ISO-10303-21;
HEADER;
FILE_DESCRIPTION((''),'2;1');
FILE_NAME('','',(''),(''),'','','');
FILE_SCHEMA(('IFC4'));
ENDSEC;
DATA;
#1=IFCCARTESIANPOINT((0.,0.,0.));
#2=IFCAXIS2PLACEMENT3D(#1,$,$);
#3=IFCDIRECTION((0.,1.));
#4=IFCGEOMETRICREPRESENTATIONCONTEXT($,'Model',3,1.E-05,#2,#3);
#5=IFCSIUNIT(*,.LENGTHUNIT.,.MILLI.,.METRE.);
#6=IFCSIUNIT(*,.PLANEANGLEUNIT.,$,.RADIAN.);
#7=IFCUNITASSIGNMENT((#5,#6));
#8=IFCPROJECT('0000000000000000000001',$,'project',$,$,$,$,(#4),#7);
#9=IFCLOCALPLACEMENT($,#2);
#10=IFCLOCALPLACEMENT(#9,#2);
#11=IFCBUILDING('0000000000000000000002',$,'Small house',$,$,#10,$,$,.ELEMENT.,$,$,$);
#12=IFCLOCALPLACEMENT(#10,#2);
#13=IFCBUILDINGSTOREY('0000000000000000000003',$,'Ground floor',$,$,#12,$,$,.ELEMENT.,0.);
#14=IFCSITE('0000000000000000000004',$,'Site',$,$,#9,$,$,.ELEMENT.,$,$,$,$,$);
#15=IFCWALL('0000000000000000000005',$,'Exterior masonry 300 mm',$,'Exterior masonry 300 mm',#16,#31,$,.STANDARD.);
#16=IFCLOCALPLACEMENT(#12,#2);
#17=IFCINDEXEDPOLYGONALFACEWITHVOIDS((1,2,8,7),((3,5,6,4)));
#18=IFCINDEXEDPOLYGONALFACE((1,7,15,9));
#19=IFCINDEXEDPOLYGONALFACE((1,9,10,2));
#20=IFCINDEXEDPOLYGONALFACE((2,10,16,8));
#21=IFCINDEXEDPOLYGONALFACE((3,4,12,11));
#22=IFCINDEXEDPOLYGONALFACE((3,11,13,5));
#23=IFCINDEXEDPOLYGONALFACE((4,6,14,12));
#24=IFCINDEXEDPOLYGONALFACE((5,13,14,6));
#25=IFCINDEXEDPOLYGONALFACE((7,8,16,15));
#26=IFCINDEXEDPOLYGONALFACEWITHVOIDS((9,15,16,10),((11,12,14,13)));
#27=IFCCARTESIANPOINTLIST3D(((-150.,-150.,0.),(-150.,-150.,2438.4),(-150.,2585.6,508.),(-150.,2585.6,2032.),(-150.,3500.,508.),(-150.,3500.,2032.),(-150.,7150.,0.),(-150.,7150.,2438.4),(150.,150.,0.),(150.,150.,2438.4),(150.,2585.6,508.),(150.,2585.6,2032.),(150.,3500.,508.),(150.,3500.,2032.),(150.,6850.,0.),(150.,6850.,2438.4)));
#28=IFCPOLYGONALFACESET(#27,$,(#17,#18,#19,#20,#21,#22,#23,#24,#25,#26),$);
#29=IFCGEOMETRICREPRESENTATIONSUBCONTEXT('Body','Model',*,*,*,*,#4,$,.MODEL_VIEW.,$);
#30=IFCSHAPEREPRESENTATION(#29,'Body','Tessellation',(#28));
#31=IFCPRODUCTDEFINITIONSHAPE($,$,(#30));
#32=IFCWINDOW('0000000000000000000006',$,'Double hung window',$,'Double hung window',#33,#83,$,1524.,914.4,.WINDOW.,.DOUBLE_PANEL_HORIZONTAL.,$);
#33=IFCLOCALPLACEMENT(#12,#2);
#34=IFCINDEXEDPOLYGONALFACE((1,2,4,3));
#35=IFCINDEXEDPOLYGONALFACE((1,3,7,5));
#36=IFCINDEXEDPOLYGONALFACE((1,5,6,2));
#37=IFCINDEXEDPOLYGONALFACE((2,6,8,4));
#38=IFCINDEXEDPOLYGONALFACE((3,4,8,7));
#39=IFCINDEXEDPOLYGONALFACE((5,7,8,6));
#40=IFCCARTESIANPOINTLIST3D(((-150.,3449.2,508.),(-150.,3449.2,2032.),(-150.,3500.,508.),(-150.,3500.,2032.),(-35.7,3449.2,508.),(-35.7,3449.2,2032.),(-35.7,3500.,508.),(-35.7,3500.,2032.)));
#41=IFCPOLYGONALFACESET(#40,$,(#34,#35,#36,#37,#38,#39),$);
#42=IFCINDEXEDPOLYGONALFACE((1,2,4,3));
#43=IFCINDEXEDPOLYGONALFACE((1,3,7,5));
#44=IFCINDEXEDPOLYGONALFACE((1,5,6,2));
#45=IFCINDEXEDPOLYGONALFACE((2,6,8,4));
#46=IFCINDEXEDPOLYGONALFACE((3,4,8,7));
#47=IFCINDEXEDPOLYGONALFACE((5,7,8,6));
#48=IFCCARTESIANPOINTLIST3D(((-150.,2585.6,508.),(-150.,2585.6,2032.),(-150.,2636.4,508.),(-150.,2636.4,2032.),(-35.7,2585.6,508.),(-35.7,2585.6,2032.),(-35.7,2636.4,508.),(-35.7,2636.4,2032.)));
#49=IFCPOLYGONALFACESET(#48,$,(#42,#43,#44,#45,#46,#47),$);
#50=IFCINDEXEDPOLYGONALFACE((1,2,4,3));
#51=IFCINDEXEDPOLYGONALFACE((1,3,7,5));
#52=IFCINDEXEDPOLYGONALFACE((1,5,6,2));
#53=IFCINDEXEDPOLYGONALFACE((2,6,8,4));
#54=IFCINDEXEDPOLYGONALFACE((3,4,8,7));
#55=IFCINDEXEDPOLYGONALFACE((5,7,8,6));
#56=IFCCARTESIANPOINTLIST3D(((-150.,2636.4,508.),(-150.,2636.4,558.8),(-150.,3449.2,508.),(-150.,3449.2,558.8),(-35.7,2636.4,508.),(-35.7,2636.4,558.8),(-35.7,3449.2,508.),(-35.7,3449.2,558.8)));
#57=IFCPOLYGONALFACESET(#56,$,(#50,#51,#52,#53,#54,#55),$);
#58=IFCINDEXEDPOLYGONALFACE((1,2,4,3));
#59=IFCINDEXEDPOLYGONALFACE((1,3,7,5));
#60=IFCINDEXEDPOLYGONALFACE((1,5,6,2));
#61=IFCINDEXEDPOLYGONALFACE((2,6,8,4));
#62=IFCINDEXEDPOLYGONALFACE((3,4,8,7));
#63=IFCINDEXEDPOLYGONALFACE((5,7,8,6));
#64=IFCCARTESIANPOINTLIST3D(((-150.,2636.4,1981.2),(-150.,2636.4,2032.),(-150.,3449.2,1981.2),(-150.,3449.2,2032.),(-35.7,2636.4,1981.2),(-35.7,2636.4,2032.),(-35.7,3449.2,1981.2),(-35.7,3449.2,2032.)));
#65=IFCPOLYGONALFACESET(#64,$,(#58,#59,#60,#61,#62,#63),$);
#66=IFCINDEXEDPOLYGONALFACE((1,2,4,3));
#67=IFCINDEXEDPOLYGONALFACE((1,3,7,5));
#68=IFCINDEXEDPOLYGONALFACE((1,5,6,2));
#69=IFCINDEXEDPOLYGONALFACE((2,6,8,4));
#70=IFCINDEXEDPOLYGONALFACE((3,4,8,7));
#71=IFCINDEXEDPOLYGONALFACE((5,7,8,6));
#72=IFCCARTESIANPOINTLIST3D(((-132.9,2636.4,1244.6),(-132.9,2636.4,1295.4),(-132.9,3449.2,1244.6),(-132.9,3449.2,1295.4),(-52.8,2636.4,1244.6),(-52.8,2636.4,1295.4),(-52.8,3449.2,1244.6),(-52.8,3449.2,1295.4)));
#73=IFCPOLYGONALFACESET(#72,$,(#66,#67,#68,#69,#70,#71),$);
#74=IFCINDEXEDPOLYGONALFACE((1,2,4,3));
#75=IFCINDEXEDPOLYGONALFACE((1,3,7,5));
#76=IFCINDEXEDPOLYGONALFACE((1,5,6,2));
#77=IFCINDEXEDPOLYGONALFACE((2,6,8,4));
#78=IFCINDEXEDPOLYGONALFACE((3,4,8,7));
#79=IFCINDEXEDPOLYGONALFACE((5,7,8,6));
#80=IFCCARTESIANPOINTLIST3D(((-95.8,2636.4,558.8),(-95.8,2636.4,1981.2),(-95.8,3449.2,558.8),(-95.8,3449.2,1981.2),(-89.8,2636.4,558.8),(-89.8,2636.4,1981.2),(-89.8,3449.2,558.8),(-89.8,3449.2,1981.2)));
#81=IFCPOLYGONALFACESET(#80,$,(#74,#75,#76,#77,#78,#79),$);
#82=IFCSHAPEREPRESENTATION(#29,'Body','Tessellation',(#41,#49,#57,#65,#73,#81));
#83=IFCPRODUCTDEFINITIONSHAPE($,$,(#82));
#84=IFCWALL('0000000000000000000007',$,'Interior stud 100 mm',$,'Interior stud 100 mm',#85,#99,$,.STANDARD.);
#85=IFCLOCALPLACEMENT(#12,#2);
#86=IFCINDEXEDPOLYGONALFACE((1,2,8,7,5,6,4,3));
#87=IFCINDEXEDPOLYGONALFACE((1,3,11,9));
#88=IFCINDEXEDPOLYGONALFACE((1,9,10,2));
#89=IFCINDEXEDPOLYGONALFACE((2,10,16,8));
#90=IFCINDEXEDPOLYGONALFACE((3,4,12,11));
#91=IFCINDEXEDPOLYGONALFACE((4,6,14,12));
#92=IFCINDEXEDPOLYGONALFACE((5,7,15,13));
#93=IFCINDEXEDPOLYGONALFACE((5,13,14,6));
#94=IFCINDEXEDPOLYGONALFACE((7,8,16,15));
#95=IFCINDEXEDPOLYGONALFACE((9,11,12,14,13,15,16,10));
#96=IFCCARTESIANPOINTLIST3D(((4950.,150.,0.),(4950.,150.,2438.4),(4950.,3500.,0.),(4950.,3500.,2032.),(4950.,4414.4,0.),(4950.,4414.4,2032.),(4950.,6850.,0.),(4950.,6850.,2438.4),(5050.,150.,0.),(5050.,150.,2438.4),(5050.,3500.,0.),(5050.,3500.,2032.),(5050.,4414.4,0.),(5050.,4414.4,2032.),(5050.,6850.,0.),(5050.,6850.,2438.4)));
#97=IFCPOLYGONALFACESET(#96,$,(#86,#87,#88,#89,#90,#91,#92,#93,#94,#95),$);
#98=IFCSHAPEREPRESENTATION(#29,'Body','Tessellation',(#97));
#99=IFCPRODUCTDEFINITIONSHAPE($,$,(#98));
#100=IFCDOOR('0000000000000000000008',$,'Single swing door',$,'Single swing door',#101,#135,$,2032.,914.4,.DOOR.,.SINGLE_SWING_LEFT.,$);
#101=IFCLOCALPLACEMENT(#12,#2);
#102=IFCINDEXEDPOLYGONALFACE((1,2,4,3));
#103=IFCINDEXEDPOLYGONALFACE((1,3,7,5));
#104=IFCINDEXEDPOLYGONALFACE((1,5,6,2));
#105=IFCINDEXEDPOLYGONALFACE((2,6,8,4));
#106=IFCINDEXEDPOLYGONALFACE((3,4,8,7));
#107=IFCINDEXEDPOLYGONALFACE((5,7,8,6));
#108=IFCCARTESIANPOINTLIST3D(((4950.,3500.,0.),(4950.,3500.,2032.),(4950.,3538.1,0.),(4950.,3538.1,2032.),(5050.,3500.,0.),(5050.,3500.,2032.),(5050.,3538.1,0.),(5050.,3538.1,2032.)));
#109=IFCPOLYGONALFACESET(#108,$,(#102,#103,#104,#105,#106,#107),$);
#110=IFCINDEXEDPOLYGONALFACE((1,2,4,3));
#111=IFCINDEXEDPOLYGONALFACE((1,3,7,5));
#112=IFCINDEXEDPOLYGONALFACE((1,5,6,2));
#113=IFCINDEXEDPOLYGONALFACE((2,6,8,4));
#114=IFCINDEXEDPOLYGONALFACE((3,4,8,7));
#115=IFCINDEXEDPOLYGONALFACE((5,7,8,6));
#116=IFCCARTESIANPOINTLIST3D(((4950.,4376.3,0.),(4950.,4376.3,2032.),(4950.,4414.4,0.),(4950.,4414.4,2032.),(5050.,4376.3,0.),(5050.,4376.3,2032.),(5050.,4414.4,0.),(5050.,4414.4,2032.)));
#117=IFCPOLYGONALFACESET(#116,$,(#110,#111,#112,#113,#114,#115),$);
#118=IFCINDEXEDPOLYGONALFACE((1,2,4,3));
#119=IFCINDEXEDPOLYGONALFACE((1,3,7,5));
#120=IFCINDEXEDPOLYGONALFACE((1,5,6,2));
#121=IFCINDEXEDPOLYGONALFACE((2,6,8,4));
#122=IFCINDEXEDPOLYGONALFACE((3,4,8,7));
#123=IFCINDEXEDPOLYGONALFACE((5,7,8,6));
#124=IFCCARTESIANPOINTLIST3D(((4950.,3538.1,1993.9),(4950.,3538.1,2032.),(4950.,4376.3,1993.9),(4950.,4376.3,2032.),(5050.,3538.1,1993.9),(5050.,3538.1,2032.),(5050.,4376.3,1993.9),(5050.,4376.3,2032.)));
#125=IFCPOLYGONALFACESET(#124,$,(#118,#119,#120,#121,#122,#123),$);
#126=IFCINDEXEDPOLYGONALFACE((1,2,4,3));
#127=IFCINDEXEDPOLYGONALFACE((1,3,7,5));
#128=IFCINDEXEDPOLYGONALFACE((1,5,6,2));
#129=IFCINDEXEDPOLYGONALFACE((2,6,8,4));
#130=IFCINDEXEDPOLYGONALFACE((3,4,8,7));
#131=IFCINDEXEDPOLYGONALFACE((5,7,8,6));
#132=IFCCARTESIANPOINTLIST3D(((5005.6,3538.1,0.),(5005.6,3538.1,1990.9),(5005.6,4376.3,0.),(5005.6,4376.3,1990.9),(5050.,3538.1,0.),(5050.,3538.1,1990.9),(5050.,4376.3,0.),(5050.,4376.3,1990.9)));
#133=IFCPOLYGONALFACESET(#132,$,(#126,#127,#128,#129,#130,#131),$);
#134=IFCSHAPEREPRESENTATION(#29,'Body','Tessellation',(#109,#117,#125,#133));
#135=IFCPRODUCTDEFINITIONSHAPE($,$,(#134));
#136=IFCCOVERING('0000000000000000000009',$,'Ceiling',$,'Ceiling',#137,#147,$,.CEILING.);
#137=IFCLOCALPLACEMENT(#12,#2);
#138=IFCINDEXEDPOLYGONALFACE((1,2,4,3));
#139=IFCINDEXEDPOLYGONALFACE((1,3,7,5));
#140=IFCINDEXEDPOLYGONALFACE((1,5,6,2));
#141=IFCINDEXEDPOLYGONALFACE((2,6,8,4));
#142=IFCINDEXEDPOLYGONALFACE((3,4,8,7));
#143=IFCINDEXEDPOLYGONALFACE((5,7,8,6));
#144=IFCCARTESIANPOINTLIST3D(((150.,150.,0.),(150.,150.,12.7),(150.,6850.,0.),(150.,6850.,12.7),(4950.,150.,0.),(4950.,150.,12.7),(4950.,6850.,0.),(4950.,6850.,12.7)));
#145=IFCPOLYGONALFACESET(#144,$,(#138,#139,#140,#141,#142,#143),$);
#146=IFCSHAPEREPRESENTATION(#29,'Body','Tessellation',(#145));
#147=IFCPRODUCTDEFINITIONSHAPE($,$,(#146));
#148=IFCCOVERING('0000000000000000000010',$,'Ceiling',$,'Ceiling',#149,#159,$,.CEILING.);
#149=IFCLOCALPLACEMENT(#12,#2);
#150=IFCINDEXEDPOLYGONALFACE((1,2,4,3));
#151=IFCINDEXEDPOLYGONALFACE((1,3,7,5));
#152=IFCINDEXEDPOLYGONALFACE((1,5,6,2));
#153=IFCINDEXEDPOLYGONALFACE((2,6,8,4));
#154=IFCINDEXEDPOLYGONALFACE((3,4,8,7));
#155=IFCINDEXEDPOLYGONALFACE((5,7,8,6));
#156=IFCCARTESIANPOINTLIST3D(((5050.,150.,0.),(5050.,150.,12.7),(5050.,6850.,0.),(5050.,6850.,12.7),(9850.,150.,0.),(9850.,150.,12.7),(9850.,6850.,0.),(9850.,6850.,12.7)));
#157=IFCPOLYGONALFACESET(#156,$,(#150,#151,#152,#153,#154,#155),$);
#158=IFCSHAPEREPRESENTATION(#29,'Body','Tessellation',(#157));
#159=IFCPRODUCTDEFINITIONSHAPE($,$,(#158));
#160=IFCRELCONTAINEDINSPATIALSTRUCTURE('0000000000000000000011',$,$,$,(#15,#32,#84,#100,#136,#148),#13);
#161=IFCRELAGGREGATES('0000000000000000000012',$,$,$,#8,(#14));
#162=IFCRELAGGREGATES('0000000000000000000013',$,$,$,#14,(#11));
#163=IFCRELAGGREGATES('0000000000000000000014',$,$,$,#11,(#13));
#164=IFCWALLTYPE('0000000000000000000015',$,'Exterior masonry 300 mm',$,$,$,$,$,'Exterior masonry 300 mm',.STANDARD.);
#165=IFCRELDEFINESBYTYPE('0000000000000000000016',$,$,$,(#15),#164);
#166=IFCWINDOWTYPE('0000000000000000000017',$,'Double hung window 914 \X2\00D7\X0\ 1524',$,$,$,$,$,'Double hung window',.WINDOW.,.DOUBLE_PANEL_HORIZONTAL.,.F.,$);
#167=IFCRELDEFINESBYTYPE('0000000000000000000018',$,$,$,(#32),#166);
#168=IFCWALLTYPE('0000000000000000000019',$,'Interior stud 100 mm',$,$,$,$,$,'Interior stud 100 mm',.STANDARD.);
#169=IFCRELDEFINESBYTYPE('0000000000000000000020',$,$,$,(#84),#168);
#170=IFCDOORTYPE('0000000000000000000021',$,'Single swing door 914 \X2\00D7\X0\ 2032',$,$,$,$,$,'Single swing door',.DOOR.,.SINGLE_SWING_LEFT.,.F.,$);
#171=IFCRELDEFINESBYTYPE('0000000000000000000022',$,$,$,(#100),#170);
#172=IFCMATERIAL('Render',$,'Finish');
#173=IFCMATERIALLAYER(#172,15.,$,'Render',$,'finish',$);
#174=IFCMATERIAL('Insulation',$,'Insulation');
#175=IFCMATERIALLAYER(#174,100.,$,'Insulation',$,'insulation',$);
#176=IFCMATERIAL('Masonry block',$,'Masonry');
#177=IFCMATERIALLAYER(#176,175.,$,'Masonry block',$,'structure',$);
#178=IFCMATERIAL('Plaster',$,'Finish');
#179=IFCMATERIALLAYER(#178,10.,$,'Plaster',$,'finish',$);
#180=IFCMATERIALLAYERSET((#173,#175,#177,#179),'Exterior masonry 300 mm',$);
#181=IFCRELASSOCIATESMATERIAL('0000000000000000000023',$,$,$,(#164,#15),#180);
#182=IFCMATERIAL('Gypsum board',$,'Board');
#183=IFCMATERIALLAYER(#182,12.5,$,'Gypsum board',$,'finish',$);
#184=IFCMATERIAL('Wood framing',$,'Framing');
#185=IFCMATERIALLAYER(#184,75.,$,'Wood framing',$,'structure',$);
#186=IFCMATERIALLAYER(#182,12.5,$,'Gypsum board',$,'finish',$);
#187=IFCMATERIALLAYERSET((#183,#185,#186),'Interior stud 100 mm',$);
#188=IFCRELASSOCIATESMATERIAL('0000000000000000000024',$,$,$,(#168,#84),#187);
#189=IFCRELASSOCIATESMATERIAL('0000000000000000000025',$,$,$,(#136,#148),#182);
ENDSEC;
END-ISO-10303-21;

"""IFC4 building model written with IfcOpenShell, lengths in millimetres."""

from ifc_helpers import new_model, si_unit, direction, frame, origin, origin_with_axes, place, context, subcontext, project, spatial, polyline, outline, extrude, material, layer, layer_set, layer_usage, type_object, element, fill, save


model = new_model("IFC4")

# Units and contexts
model_context = context("Model", 3, precision=1e-05, world=origin(), true_north=direction((0.0, 1.0)))
body_context = subcontext(model_context, "Body", "Model", "MODEL_VIEW")
ifc_project = project(units=[si_unit("LENGTHUNIT", "METRE", prefix="MILLI"), si_unit("PLANEANGLEUNIT", "RADIAN")], contexts=[model_context])

# Site, building, storey
site_placement = place(None, origin())
site = spatial("IfcSite", under=ifc_project, at=site_placement, Name="Site", CompositionType="ELEMENT")
building_placement = place(site_placement, origin())
building = spatial("IfcBuilding", under=site, at=building_placement, Name="Small house", CompositionType="ELEMENT")
storey_placement = place(building_placement, origin())
storey = spatial("IfcBuildingStorey", under=building, at=storey_placement, Name="Ground floor", CompositionType="ELEMENT", Elevation=0.0)

# Shared definitions
ifc_material_1 = material(Name="Render", Category="Finish")
ifc_layer_1 = layer(ifc_material_1, 15.0, Name="Render", Category="finish")
ifc_material_2 = material(Name="Insulation", Category="Insulation")
ifc_layer_2 = layer(ifc_material_2, 100.0, Name="Insulation", Category="insulation")
ifc_material_3 = material(Name="Masonry block", Category="Masonry")
ifc_layer_3 = layer(ifc_material_3, 175.0, Name="Masonry block", Category="structure")
ifc_material_4 = material(Name="Plaster", Category="Finish")
ifc_layer_4 = layer(ifc_material_4, 10.0, Name="Plaster", Category="finish")
ifc_layer_set_1 = layer_set([ifc_layer_1, ifc_layer_2, ifc_layer_3, ifc_layer_4], Name="Exterior masonry 300 mm")
wall_type_1 = type_object("IfcWallType", Name="Exterior masonry 300 mm", ElementType="Exterior masonry 300 mm", PredefinedType="STANDARD", material=ifc_layer_set_1)
door_type = type_object("IfcDoorType", Name="Single swing door 914 × 2032", ElementType="Single swing door", OperationType="SINGLE_SWING_LEFT", ParameterTakesPrecedence=False, PredefinedType="DOOR")
window_type = type_object("IfcWindowType", Name="Double hung window 914 × 1524", ElementType="Double hung window", ParameterTakesPrecedence=False, PartitioningType="DOUBLE_PANEL_HORIZONTAL", PredefinedType="WINDOW")

# Wall, opening, window
ifc_layer_usage_1 = layer_usage(ifc_layer_set_1, "AXIS2", "POSITIVE", -150.0)
wall_1_placement = place(storey_placement, frame((0.0, 7000.0, 0.0), z_axis=(0.0, 0.0, 1.0), x_axis=(0.0, -1.0, 0.0)))
wall_1 = element("IfcWall", 1, at=wall_1_placement, inside=storey, type_object=wall_type_1, material=ifc_layer_usage_1, Name="Exterior masonry 300 mm", ObjectType="Exterior masonry 300 mm", PredefinedType="STANDARD", context=body_context, shape_type="SweptSolid", body=[
    extrude(outline(polyline([(-150.0, -150.0), (7150.0, -150.0), (6850.0, 150.0), (150.0, 150.0), (-150.0, -150.0)])), origin(), (0.0, 0.0, 1.0), 2438.4),
])
opening_1_placement = place(wall_1_placement, frame((3500.0, 0.0, 508.0), z_axis=(0.0, 0.0, 1.0), x_axis=(1.0, 0.0, 0.0)))
opening_1 = element("IfcOpeningElement", 2, at=opening_1_placement, cuts=wall_1, PredefinedType="OPENING", context=body_context, shape_type="SweptSolid", body=[
    extrude(outline(polyline([(0.0, -160.0), (914.4, -160.0), (914.4, 160.0), (0.0, 160.0), (0.0, -160.0)])), origin(), (0.0, 0.0, 1.0), 1524.0),
])
window_1_placement = place(opening_1_placement, origin_with_axes())
window_1 = element("IfcWindow", 3, at=window_1_placement, inside=storey, type_object=window_type, Name="Double hung window", ObjectType="Double hung window", OverallHeight=1524.0, OverallWidth=914.4, PartitioningType="DOUBLE_PANEL_HORIZONTAL", PredefinedType="WINDOW", context=body_context, shape_type="SweptSolid", body=[
    extrude(outline(polyline([(0.0, -150.0), (50.8, -150.0), (50.8, -35.7), (0.0, -35.7), (0.0, -150.0)])), origin(), (0.0, 0.0, 1.0), 1524.0),
    extrude(outline(polyline([(863.6, -150.0), (914.4, -150.0), (914.4, -35.7), (863.6, -35.7), (863.6, -150.0)])), origin(), (0.0, 0.0, 1.0), 1524.0),
    extrude(outline(polyline([(50.8, -150.0), (863.6, -150.0), (863.6, -35.7), (50.8, -35.7), (50.8, -150.0)])), origin(), (0.0, 0.0, 1.0), 50.8),
    extrude(outline(polyline([(50.8, -150.0), (863.6, -150.0), (863.6, -35.7), (50.8, -35.7), (50.8, -150.0)])), frame((0.0, 0.0, 1473.2)), (0.0, 0.0, 1.0), 50.8),
    extrude(outline(polyline([(50.8, -132.9), (863.6, -132.9), (863.6, -52.8), (50.8, -52.8), (50.8, -132.9)])), frame((0.0, 0.0, 736.6)), (0.0, 0.0, 1.0), 50.8),
    extrude(outline(polyline([(50.8, -95.8), (863.6, -95.8), (863.6, -89.8), (50.8, -89.8), (50.8, -95.8)])), frame((0.0, 0.0, 50.8)), (0.0, 0.0, 1.0), 1422.4),
])
fill(opening_1, window_1)

# Wall, opening, door
ifc_material_5 = material(Name="Gypsum board", Category="Board")
ifc_layer_5 = layer(ifc_material_5, 12.5, Name="Gypsum board", Category="finish")
ifc_material_6 = material(Name="Wood framing", Category="Framing")
ifc_layer_6 = layer(ifc_material_6, 75.0, Name="Wood framing", Category="structure")
ifc_layer_7 = layer(ifc_material_5, 12.5, Name="Gypsum board", Category="finish")
ifc_layer_set_2 = layer_set([ifc_layer_5, ifc_layer_6, ifc_layer_7], Name="Interior stud 100 mm")
ifc_layer_usage_2 = layer_usage(ifc_layer_set_2, "AXIS2", "NEGATIVE", 50.0)
wall_type_2 = type_object("IfcWallType", Name="Interior stud 100 mm", ElementType="Interior stud 100 mm", PredefinedType="STANDARD", material=ifc_layer_set_2)
wall_2_placement = place(storey_placement, frame((5000.0, 0.0, 0.0), z_axis=(0.0, 0.0, 1.0), x_axis=(0.0, 1.0, 0.0)))
wall_2 = element("IfcWall", 4, at=wall_2_placement, inside=storey, type_object=wall_type_2, material=ifc_layer_usage_2, Name="Interior stud 100 mm", ObjectType="Interior stud 100 mm", PredefinedType="STANDARD", context=body_context, shape_type="SweptSolid", body=[
    extrude(outline(polyline([(150.0, -50.0), (6850.0, -50.0), (6850.0, 50.0), (150.0, 50.0), (150.0, -50.0)])), origin(), (0.0, 0.0, 1.0), 2438.4),
])
opening_2_placement = place(wall_2_placement, frame((3500.0, 0.0, 0.0), z_axis=(0.0, 0.0, 1.0), x_axis=(1.0, 0.0, 0.0)))
opening_2 = element("IfcOpeningElement", 5, at=opening_2_placement, cuts=wall_2, PredefinedType="OPENING", context=body_context, shape_type="SweptSolid", body=[
    extrude(outline(polyline([(0.0, -60.0), (914.4, -60.0), (914.4, 60.0), (0.0, 60.0), (0.0, -60.0)])), origin(), (0.0, 0.0, 1.0), 2032.0),
])
door_1_placement = place(opening_2_placement, origin_with_axes())
door_1 = element("IfcDoor", 6, at=door_1_placement, inside=storey, type_object=door_type, Name="Single swing door", ObjectType="Single swing door", OperationType="SINGLE_SWING_LEFT", OverallHeight=2032.0, OverallWidth=914.4, PredefinedType="DOOR", context=body_context, shape_type="SweptSolid", body=[
    extrude(outline(polyline([(0.0, -50.0), (38.1, -50.0), (38.1, 50.0), (0.0, 50.0), (0.0, -50.0)])), origin(), (0.0, 0.0, 1.0), 2032.0),
    extrude(outline(polyline([(876.3, -50.0), (914.4, -50.0), (914.4, 50.0), (876.3, 50.0), (876.3, -50.0)])), origin(), (0.0, 0.0, 1.0), 2032.0),
    extrude(outline(polyline([(38.1, -50.0), (876.3, -50.0), (876.3, 50.0), (38.1, 50.0), (38.1, -50.0)])), frame((0.0, 0.0, 1993.9)), (0.0, 0.0, 1.0), 38.1),
    extrude(outline(polyline([(38.1, -50.0), (876.3, -50.0), (876.3, -5.5), (38.1, -5.5), (38.1, -50.0)])), origin(), (0.0, 0.0, 1.0), 1990.9),
])
fill(opening_2, door_1)

# Coverings
covering_1_placement = place(storey_placement, origin_with_axes())
element("IfcCovering", 7, at=covering_1_placement, inside=storey, material=ifc_material_5, Name="Ceiling", ObjectType="Ceiling", PredefinedType="CEILING", context=body_context, shape_type="SweptSolid", body=[
    extrude(outline(polyline([(150.0, 150.0), (4950.0, 150.0), (4950.0, 6850.0), (150.0, 6850.0), (150.0, 150.0)])), origin(), (0.0, 0.0, 1.0), 12.7),
])
covering_2_placement = place(storey_placement, origin_with_axes())
element("IfcCovering", 8, at=covering_2_placement, inside=storey, material=ifc_material_5, Name="Ceiling", ObjectType="Ceiling", PredefinedType="CEILING", context=body_context, shape_type="SweptSolid", body=[
    extrude(outline(polyline([(5050.0, 150.0), (9850.0, 150.0), (9850.0, 6850.0), (5050.0, 6850.0), (5050.0, 150.0)])), origin(), (0.0, 0.0, 1.0), 12.7),
])

save(model, "model.ifc")
